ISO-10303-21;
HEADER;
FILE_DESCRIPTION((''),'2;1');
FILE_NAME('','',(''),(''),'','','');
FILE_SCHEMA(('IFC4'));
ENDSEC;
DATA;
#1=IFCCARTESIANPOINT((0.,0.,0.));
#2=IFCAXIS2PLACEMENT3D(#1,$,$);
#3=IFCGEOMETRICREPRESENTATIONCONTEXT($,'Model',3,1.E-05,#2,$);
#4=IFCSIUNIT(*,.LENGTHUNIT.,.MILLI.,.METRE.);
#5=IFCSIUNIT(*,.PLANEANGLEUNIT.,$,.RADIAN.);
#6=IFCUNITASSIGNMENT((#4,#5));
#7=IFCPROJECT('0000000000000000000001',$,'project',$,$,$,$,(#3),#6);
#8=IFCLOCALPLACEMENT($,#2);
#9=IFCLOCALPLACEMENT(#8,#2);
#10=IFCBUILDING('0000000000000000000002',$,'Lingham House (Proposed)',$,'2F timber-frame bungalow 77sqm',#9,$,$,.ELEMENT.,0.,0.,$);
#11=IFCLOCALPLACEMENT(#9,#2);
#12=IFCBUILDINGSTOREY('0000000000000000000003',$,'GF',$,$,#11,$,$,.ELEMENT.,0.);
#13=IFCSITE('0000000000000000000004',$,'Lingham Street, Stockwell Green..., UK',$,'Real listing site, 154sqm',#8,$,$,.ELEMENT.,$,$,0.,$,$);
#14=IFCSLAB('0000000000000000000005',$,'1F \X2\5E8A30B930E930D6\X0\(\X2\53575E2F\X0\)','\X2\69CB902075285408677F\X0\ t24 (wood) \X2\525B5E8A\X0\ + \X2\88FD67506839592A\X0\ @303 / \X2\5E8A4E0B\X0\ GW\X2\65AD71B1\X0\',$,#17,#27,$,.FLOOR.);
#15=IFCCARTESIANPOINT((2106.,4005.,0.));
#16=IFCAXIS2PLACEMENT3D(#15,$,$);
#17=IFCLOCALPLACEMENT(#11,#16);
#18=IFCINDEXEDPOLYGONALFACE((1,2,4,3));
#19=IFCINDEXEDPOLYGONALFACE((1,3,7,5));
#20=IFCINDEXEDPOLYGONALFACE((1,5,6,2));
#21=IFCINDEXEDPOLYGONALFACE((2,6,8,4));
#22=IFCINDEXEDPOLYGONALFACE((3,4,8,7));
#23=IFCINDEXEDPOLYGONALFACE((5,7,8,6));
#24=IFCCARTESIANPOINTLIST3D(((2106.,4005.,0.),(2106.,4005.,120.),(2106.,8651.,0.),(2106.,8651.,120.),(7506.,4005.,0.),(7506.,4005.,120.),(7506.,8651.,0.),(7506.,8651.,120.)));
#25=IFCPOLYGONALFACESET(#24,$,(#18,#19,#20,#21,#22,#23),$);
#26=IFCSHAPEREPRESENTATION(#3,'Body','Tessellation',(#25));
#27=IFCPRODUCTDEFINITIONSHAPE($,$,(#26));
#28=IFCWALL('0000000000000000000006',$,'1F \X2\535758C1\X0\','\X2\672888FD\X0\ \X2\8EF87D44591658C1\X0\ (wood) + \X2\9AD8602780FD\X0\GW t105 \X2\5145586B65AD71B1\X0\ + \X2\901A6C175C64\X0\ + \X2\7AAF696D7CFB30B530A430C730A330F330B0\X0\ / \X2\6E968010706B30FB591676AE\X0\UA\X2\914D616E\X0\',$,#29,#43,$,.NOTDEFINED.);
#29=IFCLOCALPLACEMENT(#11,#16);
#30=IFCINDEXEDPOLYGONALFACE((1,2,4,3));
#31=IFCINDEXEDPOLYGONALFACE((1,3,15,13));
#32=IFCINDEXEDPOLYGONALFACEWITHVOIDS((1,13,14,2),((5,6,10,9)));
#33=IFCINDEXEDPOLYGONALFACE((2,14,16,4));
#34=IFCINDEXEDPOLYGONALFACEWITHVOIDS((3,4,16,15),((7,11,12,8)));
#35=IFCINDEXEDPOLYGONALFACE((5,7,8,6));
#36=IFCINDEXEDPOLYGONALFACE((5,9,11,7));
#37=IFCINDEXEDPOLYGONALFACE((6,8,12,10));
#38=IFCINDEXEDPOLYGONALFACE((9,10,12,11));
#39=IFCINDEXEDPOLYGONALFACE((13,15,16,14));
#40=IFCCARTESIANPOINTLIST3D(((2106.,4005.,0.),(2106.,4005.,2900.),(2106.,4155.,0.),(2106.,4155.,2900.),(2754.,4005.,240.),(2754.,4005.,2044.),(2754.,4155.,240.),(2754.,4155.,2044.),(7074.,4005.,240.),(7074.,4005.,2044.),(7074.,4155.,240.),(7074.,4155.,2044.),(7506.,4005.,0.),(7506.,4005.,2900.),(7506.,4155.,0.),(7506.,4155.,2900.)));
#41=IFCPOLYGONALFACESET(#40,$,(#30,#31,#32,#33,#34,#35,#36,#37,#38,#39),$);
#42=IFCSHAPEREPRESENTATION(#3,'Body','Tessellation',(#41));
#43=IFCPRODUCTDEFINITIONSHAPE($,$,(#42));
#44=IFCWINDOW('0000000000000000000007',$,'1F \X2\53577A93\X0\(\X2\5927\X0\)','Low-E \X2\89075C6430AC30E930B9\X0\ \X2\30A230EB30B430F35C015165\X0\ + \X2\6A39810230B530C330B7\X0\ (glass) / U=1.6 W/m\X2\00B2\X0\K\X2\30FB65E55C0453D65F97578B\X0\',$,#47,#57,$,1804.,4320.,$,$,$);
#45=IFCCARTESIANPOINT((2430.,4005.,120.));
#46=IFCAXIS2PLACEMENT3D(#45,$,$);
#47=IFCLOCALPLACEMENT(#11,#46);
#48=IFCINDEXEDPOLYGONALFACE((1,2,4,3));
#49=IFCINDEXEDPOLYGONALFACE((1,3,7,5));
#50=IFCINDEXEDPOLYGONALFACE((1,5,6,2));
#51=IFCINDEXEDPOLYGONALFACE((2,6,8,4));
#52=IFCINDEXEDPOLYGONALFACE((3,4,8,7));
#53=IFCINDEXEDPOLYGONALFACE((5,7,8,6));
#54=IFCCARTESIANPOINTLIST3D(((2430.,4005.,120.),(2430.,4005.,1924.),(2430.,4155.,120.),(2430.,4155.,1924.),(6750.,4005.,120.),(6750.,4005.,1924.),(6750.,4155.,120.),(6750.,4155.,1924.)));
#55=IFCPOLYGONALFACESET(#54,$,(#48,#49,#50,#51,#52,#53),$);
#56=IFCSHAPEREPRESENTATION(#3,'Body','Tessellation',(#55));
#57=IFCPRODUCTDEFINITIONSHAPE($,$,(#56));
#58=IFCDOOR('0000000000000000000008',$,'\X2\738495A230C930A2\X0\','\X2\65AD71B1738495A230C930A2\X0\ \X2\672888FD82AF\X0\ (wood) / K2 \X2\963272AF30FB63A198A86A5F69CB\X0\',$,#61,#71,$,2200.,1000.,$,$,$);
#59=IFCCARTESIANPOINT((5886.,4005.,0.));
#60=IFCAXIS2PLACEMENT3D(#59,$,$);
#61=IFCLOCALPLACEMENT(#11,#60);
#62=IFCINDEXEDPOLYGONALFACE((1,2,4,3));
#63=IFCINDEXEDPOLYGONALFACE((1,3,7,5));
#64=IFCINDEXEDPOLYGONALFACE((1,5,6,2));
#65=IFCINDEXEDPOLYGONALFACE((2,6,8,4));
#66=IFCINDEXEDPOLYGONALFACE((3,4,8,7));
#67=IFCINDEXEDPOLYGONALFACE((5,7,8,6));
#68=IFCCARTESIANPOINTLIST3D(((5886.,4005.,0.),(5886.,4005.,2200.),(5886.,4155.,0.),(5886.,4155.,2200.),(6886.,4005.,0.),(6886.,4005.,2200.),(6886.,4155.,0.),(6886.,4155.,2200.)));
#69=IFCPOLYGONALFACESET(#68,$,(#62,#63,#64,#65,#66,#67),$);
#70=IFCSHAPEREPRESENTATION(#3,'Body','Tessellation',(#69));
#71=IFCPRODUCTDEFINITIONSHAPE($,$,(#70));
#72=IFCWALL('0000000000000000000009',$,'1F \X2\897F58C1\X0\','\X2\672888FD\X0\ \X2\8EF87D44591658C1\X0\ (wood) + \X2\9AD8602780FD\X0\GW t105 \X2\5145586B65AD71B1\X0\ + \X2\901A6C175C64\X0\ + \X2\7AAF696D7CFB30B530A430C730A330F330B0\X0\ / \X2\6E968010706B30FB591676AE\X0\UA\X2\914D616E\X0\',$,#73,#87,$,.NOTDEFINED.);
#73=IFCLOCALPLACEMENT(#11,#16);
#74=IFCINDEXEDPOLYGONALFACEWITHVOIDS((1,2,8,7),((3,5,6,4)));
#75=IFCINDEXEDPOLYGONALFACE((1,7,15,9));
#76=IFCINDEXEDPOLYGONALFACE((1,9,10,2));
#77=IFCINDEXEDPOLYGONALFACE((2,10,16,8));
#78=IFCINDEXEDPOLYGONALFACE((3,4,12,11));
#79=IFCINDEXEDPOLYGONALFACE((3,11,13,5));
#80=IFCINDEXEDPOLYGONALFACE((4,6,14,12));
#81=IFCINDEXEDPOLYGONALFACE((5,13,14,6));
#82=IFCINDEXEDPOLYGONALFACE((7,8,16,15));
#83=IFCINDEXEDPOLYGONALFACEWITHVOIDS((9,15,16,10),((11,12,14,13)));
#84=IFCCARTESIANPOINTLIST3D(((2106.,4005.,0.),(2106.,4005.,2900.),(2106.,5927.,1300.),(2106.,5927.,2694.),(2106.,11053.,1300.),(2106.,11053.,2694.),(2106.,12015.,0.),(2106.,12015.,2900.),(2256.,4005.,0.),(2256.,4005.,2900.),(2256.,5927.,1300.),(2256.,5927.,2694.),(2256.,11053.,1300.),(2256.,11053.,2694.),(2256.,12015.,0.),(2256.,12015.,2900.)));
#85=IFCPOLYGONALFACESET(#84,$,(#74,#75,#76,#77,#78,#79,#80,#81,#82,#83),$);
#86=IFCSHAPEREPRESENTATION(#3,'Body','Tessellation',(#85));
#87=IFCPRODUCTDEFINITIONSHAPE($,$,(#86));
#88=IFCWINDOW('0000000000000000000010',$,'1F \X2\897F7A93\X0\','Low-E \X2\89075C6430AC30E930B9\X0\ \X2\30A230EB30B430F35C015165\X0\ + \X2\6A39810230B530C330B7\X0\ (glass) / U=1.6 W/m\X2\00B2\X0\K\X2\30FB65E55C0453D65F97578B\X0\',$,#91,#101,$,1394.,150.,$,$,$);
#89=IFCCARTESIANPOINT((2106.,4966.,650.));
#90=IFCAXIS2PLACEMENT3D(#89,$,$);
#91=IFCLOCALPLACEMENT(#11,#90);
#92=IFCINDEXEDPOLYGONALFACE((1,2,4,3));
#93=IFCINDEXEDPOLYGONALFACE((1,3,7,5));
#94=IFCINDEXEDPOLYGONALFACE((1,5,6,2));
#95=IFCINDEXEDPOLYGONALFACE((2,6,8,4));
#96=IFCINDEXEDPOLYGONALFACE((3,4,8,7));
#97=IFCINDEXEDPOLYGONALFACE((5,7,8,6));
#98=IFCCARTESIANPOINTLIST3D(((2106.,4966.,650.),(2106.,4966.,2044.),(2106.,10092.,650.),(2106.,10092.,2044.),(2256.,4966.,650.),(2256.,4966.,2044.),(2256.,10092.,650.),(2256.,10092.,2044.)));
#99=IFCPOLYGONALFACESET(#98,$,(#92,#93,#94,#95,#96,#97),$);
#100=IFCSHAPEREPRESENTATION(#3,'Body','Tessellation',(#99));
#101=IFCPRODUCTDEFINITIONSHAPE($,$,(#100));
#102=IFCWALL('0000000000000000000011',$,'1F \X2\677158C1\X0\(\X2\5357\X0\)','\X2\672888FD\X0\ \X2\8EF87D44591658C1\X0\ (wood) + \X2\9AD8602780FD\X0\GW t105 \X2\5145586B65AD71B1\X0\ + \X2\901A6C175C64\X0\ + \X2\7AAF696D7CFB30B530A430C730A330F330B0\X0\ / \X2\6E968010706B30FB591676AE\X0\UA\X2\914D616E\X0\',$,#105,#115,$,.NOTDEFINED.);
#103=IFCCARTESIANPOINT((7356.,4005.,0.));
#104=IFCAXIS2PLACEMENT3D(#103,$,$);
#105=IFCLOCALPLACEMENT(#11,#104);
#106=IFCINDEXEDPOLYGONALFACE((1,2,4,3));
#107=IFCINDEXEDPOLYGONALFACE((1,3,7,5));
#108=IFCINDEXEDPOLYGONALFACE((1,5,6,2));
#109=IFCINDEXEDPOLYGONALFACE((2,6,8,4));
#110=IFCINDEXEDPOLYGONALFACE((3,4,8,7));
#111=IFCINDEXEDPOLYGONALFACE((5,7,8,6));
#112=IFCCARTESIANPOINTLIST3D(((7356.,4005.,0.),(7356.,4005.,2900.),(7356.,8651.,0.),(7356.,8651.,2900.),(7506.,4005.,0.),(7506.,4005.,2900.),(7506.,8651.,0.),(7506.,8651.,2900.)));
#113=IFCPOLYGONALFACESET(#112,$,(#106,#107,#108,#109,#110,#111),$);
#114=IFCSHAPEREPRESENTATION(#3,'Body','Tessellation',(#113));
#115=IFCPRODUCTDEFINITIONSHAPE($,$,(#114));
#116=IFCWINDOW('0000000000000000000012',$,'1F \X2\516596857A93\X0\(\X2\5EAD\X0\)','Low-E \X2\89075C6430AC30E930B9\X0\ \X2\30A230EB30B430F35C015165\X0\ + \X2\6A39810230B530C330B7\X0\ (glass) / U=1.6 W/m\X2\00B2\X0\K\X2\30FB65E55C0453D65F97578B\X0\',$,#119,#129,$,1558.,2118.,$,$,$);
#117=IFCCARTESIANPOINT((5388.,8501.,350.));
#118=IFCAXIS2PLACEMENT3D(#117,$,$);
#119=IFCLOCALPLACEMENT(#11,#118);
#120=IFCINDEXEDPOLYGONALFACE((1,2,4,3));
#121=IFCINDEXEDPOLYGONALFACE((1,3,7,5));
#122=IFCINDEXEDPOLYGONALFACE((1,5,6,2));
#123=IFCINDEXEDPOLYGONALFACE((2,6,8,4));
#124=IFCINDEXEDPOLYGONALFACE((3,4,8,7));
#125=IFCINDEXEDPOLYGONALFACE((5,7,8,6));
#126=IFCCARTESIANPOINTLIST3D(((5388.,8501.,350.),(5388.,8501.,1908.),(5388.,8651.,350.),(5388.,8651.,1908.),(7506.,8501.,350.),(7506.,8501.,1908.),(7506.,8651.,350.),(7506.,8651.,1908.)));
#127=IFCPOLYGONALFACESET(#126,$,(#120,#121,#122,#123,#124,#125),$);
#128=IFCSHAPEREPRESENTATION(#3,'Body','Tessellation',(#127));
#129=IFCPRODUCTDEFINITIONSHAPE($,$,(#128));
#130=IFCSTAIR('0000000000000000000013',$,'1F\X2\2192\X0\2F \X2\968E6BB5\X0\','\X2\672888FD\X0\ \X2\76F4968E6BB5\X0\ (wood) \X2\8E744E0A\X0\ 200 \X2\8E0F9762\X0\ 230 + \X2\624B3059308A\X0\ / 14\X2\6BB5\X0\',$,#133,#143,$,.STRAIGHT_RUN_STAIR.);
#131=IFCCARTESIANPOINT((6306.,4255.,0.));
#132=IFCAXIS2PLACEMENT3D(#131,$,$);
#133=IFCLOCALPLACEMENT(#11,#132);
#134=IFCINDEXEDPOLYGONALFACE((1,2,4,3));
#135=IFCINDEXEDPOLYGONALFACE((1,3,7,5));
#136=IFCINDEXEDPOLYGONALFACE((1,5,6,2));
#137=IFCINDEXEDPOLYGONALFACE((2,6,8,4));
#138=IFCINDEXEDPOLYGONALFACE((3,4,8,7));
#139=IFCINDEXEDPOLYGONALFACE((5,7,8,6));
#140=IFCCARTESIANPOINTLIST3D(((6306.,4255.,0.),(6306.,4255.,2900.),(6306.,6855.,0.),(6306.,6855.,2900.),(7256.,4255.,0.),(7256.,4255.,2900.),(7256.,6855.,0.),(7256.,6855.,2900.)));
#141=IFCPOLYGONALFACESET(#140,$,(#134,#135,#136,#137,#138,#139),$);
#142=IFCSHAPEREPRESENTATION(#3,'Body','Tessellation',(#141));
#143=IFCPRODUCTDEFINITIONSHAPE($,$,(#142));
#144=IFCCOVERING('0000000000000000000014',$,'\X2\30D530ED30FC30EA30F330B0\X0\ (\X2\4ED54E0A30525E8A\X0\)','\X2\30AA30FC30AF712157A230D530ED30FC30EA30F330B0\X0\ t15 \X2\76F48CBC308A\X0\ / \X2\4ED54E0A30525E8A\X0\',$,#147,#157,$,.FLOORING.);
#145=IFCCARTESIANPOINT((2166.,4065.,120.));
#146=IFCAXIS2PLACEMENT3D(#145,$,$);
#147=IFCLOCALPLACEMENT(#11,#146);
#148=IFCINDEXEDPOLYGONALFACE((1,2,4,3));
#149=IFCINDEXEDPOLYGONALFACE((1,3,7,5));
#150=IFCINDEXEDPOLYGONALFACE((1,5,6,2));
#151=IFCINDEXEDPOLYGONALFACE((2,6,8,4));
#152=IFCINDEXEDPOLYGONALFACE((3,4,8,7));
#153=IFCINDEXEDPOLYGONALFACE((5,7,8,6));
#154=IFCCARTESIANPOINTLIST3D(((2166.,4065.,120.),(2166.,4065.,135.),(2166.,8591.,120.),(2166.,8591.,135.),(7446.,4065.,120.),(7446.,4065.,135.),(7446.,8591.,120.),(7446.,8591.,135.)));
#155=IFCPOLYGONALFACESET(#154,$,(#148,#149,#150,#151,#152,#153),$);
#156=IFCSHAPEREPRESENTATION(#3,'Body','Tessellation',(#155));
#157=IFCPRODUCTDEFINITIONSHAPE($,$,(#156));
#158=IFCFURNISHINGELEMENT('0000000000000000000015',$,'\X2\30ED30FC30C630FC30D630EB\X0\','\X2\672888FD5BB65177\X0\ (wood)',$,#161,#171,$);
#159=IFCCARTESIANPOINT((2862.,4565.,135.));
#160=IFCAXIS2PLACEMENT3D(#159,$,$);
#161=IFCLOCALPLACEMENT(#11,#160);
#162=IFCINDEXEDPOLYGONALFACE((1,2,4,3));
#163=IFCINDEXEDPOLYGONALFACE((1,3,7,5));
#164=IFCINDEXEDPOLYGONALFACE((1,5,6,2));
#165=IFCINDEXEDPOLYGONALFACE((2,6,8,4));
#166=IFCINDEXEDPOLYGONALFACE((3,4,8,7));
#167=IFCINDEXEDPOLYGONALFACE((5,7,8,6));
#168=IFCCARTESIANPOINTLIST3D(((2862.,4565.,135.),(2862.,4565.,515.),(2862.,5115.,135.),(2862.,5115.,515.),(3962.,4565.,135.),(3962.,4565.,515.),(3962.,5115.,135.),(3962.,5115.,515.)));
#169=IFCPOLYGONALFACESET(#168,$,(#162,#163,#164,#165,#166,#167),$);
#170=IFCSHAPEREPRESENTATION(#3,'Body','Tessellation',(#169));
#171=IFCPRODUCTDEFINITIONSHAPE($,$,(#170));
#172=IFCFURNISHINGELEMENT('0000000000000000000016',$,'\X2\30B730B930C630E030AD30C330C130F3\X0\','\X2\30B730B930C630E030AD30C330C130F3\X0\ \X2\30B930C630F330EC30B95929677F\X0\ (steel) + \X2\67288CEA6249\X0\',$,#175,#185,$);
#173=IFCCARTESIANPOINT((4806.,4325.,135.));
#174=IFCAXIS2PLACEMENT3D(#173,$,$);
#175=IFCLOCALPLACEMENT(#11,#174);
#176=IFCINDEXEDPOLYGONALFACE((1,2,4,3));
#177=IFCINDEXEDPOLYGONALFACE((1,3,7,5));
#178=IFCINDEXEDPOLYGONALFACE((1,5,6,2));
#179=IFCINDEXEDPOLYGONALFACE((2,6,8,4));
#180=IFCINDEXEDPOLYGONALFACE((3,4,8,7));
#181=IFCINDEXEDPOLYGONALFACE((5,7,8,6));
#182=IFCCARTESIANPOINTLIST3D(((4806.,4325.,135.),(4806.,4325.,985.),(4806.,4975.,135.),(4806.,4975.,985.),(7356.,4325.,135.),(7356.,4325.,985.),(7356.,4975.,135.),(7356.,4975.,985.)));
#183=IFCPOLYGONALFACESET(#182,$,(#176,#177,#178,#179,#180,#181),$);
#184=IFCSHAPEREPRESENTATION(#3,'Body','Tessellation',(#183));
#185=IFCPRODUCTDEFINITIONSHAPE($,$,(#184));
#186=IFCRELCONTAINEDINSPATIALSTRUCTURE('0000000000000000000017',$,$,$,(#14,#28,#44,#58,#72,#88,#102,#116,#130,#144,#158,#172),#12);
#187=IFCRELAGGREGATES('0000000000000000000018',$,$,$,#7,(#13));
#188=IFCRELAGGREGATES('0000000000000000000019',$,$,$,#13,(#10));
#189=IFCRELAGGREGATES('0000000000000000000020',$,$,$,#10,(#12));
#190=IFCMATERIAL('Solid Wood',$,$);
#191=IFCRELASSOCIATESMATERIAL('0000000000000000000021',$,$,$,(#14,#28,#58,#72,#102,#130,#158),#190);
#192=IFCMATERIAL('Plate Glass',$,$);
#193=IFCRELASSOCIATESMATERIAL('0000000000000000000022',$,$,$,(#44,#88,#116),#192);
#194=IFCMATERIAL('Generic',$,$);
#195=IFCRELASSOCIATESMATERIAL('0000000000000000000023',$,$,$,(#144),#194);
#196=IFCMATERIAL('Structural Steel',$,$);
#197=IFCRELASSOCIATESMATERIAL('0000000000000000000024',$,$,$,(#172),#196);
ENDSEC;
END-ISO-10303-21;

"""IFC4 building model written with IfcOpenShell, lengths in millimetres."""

from ifc_helpers import new_model, si_unit, frame, frame_2d, origin, place, context, project, spatial, rectangle, extrude, material, element, fill, save


model = new_model("IFC4")

# Units and contexts
model_context = context("Model", 3, precision=1e-05, world=origin())
ifc_project = project(units=[si_unit("LENGTHUNIT", "METRE", prefix="MILLI"), si_unit("PLANEANGLEUNIT", "RADIAN")], contexts=[model_context])

# Site, building, storey
site_placement = place(None, origin())
site = spatial("IfcSite", under=ifc_project, at=site_placement, Name="Lingham Street, Stockwell Green..., UK", ObjectType="Real listing site, 154sqm", CompositionType="ELEMENT", RefElevation=0.0)
building_placement = place(site_placement, origin())
building = spatial("IfcBuilding", under=site, at=building_placement, Name="Lingham House (Proposed)", ObjectType="2F timber-frame bungalow 77sqm", CompositionType="ELEMENT", ElevationOfRefHeight=0.0, ElevationOfTerrain=0.0)
storey_placement = place(building_placement, origin())
storey = spatial("IfcBuildingStorey", under=building, at=storey_placement, Name="GF", CompositionType="ELEMENT", Elevation=0.0)

# Slab
ifc_material_1 = material(Name="Solid Wood")
slab_1_placement = place(storey_placement, frame((2106.0, 4005.0, 0.0)))
element("IfcSlab", 1, at=slab_1_placement, inside=storey, material=ifc_material_1, Name="1F 床スラブ(南帯)", Description="構造用合板 t24 (wood) 剛床 + 製材根太 @303 / 床下 GW断熱", PredefinedType="FLOOR", context=model_context, shape_type="SweptSolid", body=[
    extrude(rectangle(XDim=5400.0, YDim=4646.0, at=frame_2d((2700.0, 2323.0))), frame((2106.0, 4005.0, 0.0)), (0.0, 0.0, 1.0), 120.0),
])

# Wall, openings, window, door
wall_1_placement = place(storey_placement, frame((2106.0, 4005.0, 0.0)))
wall_1 = element("IfcWall", 2, at=wall_1_placement, inside=storey, material=ifc_material_1, Name="1F 南壁", Description="木製 軸組外壁 (wood) + 高性能GW t105 充填断熱 + 通気層 + 窯業系サイディング / 準耐火・外皮UA配慮", PredefinedType="NOTDEFINED", context=model_context, shape_type="SweptSolid", body=[
    extrude(rectangle(XDim=5400.0, YDim=150.0, at=frame_2d((2700.0, 75.0))), frame((2106.0, 4005.0, 0.0)), (0.0, 0.0, 1.0), 2900.0),
])
opening_1_placement = place(storey_placement, frame((2430.0, 4005.0, 120.0)))
opening_1 = element("IfcOpeningElement", 3, at=opening_1_placement, cuts=wall_1, PredefinedType="NOTDEFINED", context=model_context, shape_type="SweptSolid", body=[
    extrude(rectangle(XDim=4320.0, YDim=150.0, at=frame_2d((2160.0, 75.0))), frame((2430.0, 4005.0, 120.0)), (0.0, 0.0, 1.0), 1804.0),
])
opening_2_placement = place(storey_placement, frame((5886.0, 4005.0, 0.0)))
opening_2 = element("IfcOpeningElement", 4, at=opening_2_placement, cuts=wall_1, PredefinedType="NOTDEFINED", context=model_context, shape_type="SweptSolid", body=[
    extrude(rectangle(XDim=1000.0, YDim=150.0, at=frame_2d((500.0, 75.0))), frame((5886.0, 4005.0, 0.0)), (0.0, 0.0, 1.0), 2200.0),
])
ifc_material_2 = material(Name="Plate Glass")
window_1_placement = place(storey_placement, frame((2430.0, 4005.0, 120.0)))
window_1 = element("IfcWindow", 5, at=window_1_placement, inside=storey, material=ifc_material_2, Name="1F 南窓(大)", Description="Low-E 複層ガラス アルゴン封入 + 樹脂サッシ (glass) / U=1.6 W/m²K・日射取得型", OverallHeight=1804.0, OverallWidth=4320.0, context=model_context, shape_type="SweptSolid", body=[
    extrude(rectangle(XDim=4320.0, YDim=150.0, at=frame_2d((2160.0, 75.0))), frame((2430.0, 4005.0, 120.0)), (0.0, 0.0, 1.0), 1804.0),
])
fill(opening_1, window_1)
door_1_placement = place(storey_placement, frame((5886.0, 4005.0, 0.0)))
door_1 = element("IfcDoor", 6, at=door_1_placement, inside=storey, material=ifc_material_1, Name="玄関ドア", Description="断熱玄関ドア 木製芯 (wood) / K2 防犯・採風機構", OverallHeight=2200.0, OverallWidth=1000.0, context=model_context, shape_type="SweptSolid", body=[
    extrude(rectangle(XDim=1000.0, YDim=150.0, at=frame_2d((500.0, 75.0))), frame((5886.0, 4005.0, 0.0)), (0.0, 0.0, 1.0), 2200.0),
])
fill(opening_2, door_1)

# Walls, openings, windows
wall_2_placement = place(storey_placement, frame((2106.0, 4005.0, 0.0)))
wall_2 = element("IfcWall", 7, at=wall_2_placement, inside=storey, material=ifc_material_1, Name="1F 西壁", Description="木製 軸組外壁 (wood) + 高性能GW t105 充填断熱 + 通気層 + 窯業系サイディング / 準耐火・外皮UA配慮", PredefinedType="NOTDEFINED", context=model_context, shape_type="SweptSolid", body=[
    extrude(rectangle(XDim=150.0, YDim=8010.0, at=frame_2d((75.0, 4005.0))), frame((2106.0, 4005.0, 0.0)), (0.0, 0.0, 1.0), 2900.0),
])
opening_3_placement = place(storey_placement, frame((2106.0, 4966.0, 650.0)))
opening_3 = element("IfcOpeningElement", 8, at=opening_3_placement, cuts=wall_2, PredefinedType="NOTDEFINED", context=model_context, shape_type="SweptSolid", body=[
    extrude(rectangle(XDim=150.0, YDim=5126.0, at=frame_2d((75.0, 2563.0))), frame((2106.0, 4966.0, 650.0)), (0.0, 0.0, 1.0), 1394.0),
])
window_2_placement = place(storey_placement, frame((2106.0, 4966.0, 650.0)))
window_2 = element("IfcWindow", 9, at=window_2_placement, inside=storey, material=ifc_material_2, Name="1F 西窓", Description="Low-E 複層ガラス アルゴン封入 + 樹脂サッシ (glass) / U=1.6 W/m²K・日射取得型", OverallHeight=1394.0, OverallWidth=150.0, context=model_context, shape_type="SweptSolid", body=[
    extrude(rectangle(XDim=150.0, YDim=5126.0, at=frame_2d((75.0, 2563.0))), frame((2106.0, 4966.0, 650.0)), (0.0, 0.0, 1.0), 1394.0),
])
fill(opening_3, window_2)
wall_3_placement = place(storey_placement, frame((7356.0, 4005.0, 0.0)))
wall_3 = element("IfcWall", 10, at=wall_3_placement, inside=storey, material=ifc_material_1, Name="1F 東壁(南)", Description="木製 軸組外壁 (wood) + 高性能GW t105 充填断熱 + 通気層 + 窯業系サイディング / 準耐火・外皮UA配慮", PredefinedType="NOTDEFINED", context=model_context, shape_type="SweptSolid", body=[
    extrude(rectangle(XDim=150.0, YDim=4646.0, at=frame_2d((75.0, 2323.0))), frame((7356.0, 4005.0, 0.0)), (0.0, 0.0, 1.0), 2900.0),
])
opening_4_placement = place(storey_placement, frame((5388.0, 8501.0, 350.0)))
opening_4 = element("IfcOpeningElement", 11, at=opening_4_placement, cuts=wall_3, PredefinedType="NOTDEFINED", context=model_context, shape_type="SweptSolid", body=[
    extrude(rectangle(XDim=2118.0, YDim=150.0, at=frame_2d((1059.0, 75.0))), frame((5388.0, 8501.0, 350.0)), (0.0, 0.0, 1.0), 1558.0),
])
window_3_placement = place(storey_placement, frame((5388.0, 8501.0, 350.0)))
window_3 = element("IfcWindow", 12, at=window_3_placement, inside=storey, material=ifc_material_2, Name="1F 入隅窓(庭)", Description="Low-E 複層ガラス アルゴン封入 + 樹脂サッシ (glass) / U=1.6 W/m²K・日射取得型", OverallHeight=1558.0, OverallWidth=2118.0, context=model_context, shape_type="SweptSolid", body=[
    extrude(rectangle(XDim=2118.0, YDim=150.0, at=frame_2d((1059.0, 75.0))), frame((5388.0, 8501.0, 350.0)), (0.0, 0.0, 1.0), 1558.0),
])
fill(opening_4, window_3)

# Stair
stair_placement = place(storey_placement, frame((6306.0, 4255.0, 0.0)))
element("IfcStair", 13, at=stair_placement, inside=storey, material=ifc_material_1, Name="1F→2F 階段", Description="木製 直階段 (wood) 蹴上 200 踏面 230 + 手すり / 14段", PredefinedType="STRAIGHT_RUN_STAIR", context=model_context, shape_type="SweptSolid", body=[
    extrude(rectangle(XDim=950.0, YDim=2600.0, at=frame_2d((475.0, 1300.0))), frame((6306.0, 4255.0, 0.0)), (0.0, 0.0, 1.0), 2900.0),
])

# Covering
ifc_material_3 = material(Name="Generic")
covering_placement = place(storey_placement, frame((2166.0, 4065.0, 120.0)))
element("IfcCovering", 14, at=covering_placement, inside=storey, material=ifc_material_3, Name="フローリング (仕上げ床)", Description="オーク無垢フローリング t15 直貼り / 仕上げ床", PredefinedType="FLOORING", context=model_context, shape_type="SweptSolid", body=[
    extrude(rectangle(XDim=5280.0, YDim=4526.0, at=frame_2d((2640.0, 2263.0))), frame((2166.0, 4065.0, 120.0)), (0.0, 0.0, 1.0), 15.0),
])

# Furnishing elements
furnishing_1_placement = place(storey_placement, frame((2862.0, 4565.0, 135.0)))
element("IfcFurnishingElement", 15, at=furnishing_1_placement, inside=storey, material=ifc_material_1, Name="ローテーブル", Description="木製家具 (wood)", context=model_context, shape_type="SweptSolid", body=[
    extrude(rectangle(XDim=1100.0, YDim=550.0, at=frame_2d((550.0, 275.0))), frame((2862.0, 4565.0, 135.0)), (0.0, 0.0, 1.0), 380.0),
])
ifc_material_4 = material(Name="Structural Steel")
furnishing_2_placement = place(storey_placement, frame((4806.0, 4325.0, 135.0)))
element("IfcFurnishingElement", 16, at=furnishing_2_placement, inside=storey, material=ifc_material_4, Name="システムキッチン", Description="システムキッチン ステンレス天板 (steel) + 木質扉", context=model_context, shape_type="SweptSolid", body=[
    extrude(rectangle(XDim=2550.0, YDim=650.0, at=frame_2d((1275.0, 325.0))), frame((4806.0, 4325.0, 135.0)), (0.0, 0.0, 1.0), 850.0),
])

save(model, "model.ifc")
